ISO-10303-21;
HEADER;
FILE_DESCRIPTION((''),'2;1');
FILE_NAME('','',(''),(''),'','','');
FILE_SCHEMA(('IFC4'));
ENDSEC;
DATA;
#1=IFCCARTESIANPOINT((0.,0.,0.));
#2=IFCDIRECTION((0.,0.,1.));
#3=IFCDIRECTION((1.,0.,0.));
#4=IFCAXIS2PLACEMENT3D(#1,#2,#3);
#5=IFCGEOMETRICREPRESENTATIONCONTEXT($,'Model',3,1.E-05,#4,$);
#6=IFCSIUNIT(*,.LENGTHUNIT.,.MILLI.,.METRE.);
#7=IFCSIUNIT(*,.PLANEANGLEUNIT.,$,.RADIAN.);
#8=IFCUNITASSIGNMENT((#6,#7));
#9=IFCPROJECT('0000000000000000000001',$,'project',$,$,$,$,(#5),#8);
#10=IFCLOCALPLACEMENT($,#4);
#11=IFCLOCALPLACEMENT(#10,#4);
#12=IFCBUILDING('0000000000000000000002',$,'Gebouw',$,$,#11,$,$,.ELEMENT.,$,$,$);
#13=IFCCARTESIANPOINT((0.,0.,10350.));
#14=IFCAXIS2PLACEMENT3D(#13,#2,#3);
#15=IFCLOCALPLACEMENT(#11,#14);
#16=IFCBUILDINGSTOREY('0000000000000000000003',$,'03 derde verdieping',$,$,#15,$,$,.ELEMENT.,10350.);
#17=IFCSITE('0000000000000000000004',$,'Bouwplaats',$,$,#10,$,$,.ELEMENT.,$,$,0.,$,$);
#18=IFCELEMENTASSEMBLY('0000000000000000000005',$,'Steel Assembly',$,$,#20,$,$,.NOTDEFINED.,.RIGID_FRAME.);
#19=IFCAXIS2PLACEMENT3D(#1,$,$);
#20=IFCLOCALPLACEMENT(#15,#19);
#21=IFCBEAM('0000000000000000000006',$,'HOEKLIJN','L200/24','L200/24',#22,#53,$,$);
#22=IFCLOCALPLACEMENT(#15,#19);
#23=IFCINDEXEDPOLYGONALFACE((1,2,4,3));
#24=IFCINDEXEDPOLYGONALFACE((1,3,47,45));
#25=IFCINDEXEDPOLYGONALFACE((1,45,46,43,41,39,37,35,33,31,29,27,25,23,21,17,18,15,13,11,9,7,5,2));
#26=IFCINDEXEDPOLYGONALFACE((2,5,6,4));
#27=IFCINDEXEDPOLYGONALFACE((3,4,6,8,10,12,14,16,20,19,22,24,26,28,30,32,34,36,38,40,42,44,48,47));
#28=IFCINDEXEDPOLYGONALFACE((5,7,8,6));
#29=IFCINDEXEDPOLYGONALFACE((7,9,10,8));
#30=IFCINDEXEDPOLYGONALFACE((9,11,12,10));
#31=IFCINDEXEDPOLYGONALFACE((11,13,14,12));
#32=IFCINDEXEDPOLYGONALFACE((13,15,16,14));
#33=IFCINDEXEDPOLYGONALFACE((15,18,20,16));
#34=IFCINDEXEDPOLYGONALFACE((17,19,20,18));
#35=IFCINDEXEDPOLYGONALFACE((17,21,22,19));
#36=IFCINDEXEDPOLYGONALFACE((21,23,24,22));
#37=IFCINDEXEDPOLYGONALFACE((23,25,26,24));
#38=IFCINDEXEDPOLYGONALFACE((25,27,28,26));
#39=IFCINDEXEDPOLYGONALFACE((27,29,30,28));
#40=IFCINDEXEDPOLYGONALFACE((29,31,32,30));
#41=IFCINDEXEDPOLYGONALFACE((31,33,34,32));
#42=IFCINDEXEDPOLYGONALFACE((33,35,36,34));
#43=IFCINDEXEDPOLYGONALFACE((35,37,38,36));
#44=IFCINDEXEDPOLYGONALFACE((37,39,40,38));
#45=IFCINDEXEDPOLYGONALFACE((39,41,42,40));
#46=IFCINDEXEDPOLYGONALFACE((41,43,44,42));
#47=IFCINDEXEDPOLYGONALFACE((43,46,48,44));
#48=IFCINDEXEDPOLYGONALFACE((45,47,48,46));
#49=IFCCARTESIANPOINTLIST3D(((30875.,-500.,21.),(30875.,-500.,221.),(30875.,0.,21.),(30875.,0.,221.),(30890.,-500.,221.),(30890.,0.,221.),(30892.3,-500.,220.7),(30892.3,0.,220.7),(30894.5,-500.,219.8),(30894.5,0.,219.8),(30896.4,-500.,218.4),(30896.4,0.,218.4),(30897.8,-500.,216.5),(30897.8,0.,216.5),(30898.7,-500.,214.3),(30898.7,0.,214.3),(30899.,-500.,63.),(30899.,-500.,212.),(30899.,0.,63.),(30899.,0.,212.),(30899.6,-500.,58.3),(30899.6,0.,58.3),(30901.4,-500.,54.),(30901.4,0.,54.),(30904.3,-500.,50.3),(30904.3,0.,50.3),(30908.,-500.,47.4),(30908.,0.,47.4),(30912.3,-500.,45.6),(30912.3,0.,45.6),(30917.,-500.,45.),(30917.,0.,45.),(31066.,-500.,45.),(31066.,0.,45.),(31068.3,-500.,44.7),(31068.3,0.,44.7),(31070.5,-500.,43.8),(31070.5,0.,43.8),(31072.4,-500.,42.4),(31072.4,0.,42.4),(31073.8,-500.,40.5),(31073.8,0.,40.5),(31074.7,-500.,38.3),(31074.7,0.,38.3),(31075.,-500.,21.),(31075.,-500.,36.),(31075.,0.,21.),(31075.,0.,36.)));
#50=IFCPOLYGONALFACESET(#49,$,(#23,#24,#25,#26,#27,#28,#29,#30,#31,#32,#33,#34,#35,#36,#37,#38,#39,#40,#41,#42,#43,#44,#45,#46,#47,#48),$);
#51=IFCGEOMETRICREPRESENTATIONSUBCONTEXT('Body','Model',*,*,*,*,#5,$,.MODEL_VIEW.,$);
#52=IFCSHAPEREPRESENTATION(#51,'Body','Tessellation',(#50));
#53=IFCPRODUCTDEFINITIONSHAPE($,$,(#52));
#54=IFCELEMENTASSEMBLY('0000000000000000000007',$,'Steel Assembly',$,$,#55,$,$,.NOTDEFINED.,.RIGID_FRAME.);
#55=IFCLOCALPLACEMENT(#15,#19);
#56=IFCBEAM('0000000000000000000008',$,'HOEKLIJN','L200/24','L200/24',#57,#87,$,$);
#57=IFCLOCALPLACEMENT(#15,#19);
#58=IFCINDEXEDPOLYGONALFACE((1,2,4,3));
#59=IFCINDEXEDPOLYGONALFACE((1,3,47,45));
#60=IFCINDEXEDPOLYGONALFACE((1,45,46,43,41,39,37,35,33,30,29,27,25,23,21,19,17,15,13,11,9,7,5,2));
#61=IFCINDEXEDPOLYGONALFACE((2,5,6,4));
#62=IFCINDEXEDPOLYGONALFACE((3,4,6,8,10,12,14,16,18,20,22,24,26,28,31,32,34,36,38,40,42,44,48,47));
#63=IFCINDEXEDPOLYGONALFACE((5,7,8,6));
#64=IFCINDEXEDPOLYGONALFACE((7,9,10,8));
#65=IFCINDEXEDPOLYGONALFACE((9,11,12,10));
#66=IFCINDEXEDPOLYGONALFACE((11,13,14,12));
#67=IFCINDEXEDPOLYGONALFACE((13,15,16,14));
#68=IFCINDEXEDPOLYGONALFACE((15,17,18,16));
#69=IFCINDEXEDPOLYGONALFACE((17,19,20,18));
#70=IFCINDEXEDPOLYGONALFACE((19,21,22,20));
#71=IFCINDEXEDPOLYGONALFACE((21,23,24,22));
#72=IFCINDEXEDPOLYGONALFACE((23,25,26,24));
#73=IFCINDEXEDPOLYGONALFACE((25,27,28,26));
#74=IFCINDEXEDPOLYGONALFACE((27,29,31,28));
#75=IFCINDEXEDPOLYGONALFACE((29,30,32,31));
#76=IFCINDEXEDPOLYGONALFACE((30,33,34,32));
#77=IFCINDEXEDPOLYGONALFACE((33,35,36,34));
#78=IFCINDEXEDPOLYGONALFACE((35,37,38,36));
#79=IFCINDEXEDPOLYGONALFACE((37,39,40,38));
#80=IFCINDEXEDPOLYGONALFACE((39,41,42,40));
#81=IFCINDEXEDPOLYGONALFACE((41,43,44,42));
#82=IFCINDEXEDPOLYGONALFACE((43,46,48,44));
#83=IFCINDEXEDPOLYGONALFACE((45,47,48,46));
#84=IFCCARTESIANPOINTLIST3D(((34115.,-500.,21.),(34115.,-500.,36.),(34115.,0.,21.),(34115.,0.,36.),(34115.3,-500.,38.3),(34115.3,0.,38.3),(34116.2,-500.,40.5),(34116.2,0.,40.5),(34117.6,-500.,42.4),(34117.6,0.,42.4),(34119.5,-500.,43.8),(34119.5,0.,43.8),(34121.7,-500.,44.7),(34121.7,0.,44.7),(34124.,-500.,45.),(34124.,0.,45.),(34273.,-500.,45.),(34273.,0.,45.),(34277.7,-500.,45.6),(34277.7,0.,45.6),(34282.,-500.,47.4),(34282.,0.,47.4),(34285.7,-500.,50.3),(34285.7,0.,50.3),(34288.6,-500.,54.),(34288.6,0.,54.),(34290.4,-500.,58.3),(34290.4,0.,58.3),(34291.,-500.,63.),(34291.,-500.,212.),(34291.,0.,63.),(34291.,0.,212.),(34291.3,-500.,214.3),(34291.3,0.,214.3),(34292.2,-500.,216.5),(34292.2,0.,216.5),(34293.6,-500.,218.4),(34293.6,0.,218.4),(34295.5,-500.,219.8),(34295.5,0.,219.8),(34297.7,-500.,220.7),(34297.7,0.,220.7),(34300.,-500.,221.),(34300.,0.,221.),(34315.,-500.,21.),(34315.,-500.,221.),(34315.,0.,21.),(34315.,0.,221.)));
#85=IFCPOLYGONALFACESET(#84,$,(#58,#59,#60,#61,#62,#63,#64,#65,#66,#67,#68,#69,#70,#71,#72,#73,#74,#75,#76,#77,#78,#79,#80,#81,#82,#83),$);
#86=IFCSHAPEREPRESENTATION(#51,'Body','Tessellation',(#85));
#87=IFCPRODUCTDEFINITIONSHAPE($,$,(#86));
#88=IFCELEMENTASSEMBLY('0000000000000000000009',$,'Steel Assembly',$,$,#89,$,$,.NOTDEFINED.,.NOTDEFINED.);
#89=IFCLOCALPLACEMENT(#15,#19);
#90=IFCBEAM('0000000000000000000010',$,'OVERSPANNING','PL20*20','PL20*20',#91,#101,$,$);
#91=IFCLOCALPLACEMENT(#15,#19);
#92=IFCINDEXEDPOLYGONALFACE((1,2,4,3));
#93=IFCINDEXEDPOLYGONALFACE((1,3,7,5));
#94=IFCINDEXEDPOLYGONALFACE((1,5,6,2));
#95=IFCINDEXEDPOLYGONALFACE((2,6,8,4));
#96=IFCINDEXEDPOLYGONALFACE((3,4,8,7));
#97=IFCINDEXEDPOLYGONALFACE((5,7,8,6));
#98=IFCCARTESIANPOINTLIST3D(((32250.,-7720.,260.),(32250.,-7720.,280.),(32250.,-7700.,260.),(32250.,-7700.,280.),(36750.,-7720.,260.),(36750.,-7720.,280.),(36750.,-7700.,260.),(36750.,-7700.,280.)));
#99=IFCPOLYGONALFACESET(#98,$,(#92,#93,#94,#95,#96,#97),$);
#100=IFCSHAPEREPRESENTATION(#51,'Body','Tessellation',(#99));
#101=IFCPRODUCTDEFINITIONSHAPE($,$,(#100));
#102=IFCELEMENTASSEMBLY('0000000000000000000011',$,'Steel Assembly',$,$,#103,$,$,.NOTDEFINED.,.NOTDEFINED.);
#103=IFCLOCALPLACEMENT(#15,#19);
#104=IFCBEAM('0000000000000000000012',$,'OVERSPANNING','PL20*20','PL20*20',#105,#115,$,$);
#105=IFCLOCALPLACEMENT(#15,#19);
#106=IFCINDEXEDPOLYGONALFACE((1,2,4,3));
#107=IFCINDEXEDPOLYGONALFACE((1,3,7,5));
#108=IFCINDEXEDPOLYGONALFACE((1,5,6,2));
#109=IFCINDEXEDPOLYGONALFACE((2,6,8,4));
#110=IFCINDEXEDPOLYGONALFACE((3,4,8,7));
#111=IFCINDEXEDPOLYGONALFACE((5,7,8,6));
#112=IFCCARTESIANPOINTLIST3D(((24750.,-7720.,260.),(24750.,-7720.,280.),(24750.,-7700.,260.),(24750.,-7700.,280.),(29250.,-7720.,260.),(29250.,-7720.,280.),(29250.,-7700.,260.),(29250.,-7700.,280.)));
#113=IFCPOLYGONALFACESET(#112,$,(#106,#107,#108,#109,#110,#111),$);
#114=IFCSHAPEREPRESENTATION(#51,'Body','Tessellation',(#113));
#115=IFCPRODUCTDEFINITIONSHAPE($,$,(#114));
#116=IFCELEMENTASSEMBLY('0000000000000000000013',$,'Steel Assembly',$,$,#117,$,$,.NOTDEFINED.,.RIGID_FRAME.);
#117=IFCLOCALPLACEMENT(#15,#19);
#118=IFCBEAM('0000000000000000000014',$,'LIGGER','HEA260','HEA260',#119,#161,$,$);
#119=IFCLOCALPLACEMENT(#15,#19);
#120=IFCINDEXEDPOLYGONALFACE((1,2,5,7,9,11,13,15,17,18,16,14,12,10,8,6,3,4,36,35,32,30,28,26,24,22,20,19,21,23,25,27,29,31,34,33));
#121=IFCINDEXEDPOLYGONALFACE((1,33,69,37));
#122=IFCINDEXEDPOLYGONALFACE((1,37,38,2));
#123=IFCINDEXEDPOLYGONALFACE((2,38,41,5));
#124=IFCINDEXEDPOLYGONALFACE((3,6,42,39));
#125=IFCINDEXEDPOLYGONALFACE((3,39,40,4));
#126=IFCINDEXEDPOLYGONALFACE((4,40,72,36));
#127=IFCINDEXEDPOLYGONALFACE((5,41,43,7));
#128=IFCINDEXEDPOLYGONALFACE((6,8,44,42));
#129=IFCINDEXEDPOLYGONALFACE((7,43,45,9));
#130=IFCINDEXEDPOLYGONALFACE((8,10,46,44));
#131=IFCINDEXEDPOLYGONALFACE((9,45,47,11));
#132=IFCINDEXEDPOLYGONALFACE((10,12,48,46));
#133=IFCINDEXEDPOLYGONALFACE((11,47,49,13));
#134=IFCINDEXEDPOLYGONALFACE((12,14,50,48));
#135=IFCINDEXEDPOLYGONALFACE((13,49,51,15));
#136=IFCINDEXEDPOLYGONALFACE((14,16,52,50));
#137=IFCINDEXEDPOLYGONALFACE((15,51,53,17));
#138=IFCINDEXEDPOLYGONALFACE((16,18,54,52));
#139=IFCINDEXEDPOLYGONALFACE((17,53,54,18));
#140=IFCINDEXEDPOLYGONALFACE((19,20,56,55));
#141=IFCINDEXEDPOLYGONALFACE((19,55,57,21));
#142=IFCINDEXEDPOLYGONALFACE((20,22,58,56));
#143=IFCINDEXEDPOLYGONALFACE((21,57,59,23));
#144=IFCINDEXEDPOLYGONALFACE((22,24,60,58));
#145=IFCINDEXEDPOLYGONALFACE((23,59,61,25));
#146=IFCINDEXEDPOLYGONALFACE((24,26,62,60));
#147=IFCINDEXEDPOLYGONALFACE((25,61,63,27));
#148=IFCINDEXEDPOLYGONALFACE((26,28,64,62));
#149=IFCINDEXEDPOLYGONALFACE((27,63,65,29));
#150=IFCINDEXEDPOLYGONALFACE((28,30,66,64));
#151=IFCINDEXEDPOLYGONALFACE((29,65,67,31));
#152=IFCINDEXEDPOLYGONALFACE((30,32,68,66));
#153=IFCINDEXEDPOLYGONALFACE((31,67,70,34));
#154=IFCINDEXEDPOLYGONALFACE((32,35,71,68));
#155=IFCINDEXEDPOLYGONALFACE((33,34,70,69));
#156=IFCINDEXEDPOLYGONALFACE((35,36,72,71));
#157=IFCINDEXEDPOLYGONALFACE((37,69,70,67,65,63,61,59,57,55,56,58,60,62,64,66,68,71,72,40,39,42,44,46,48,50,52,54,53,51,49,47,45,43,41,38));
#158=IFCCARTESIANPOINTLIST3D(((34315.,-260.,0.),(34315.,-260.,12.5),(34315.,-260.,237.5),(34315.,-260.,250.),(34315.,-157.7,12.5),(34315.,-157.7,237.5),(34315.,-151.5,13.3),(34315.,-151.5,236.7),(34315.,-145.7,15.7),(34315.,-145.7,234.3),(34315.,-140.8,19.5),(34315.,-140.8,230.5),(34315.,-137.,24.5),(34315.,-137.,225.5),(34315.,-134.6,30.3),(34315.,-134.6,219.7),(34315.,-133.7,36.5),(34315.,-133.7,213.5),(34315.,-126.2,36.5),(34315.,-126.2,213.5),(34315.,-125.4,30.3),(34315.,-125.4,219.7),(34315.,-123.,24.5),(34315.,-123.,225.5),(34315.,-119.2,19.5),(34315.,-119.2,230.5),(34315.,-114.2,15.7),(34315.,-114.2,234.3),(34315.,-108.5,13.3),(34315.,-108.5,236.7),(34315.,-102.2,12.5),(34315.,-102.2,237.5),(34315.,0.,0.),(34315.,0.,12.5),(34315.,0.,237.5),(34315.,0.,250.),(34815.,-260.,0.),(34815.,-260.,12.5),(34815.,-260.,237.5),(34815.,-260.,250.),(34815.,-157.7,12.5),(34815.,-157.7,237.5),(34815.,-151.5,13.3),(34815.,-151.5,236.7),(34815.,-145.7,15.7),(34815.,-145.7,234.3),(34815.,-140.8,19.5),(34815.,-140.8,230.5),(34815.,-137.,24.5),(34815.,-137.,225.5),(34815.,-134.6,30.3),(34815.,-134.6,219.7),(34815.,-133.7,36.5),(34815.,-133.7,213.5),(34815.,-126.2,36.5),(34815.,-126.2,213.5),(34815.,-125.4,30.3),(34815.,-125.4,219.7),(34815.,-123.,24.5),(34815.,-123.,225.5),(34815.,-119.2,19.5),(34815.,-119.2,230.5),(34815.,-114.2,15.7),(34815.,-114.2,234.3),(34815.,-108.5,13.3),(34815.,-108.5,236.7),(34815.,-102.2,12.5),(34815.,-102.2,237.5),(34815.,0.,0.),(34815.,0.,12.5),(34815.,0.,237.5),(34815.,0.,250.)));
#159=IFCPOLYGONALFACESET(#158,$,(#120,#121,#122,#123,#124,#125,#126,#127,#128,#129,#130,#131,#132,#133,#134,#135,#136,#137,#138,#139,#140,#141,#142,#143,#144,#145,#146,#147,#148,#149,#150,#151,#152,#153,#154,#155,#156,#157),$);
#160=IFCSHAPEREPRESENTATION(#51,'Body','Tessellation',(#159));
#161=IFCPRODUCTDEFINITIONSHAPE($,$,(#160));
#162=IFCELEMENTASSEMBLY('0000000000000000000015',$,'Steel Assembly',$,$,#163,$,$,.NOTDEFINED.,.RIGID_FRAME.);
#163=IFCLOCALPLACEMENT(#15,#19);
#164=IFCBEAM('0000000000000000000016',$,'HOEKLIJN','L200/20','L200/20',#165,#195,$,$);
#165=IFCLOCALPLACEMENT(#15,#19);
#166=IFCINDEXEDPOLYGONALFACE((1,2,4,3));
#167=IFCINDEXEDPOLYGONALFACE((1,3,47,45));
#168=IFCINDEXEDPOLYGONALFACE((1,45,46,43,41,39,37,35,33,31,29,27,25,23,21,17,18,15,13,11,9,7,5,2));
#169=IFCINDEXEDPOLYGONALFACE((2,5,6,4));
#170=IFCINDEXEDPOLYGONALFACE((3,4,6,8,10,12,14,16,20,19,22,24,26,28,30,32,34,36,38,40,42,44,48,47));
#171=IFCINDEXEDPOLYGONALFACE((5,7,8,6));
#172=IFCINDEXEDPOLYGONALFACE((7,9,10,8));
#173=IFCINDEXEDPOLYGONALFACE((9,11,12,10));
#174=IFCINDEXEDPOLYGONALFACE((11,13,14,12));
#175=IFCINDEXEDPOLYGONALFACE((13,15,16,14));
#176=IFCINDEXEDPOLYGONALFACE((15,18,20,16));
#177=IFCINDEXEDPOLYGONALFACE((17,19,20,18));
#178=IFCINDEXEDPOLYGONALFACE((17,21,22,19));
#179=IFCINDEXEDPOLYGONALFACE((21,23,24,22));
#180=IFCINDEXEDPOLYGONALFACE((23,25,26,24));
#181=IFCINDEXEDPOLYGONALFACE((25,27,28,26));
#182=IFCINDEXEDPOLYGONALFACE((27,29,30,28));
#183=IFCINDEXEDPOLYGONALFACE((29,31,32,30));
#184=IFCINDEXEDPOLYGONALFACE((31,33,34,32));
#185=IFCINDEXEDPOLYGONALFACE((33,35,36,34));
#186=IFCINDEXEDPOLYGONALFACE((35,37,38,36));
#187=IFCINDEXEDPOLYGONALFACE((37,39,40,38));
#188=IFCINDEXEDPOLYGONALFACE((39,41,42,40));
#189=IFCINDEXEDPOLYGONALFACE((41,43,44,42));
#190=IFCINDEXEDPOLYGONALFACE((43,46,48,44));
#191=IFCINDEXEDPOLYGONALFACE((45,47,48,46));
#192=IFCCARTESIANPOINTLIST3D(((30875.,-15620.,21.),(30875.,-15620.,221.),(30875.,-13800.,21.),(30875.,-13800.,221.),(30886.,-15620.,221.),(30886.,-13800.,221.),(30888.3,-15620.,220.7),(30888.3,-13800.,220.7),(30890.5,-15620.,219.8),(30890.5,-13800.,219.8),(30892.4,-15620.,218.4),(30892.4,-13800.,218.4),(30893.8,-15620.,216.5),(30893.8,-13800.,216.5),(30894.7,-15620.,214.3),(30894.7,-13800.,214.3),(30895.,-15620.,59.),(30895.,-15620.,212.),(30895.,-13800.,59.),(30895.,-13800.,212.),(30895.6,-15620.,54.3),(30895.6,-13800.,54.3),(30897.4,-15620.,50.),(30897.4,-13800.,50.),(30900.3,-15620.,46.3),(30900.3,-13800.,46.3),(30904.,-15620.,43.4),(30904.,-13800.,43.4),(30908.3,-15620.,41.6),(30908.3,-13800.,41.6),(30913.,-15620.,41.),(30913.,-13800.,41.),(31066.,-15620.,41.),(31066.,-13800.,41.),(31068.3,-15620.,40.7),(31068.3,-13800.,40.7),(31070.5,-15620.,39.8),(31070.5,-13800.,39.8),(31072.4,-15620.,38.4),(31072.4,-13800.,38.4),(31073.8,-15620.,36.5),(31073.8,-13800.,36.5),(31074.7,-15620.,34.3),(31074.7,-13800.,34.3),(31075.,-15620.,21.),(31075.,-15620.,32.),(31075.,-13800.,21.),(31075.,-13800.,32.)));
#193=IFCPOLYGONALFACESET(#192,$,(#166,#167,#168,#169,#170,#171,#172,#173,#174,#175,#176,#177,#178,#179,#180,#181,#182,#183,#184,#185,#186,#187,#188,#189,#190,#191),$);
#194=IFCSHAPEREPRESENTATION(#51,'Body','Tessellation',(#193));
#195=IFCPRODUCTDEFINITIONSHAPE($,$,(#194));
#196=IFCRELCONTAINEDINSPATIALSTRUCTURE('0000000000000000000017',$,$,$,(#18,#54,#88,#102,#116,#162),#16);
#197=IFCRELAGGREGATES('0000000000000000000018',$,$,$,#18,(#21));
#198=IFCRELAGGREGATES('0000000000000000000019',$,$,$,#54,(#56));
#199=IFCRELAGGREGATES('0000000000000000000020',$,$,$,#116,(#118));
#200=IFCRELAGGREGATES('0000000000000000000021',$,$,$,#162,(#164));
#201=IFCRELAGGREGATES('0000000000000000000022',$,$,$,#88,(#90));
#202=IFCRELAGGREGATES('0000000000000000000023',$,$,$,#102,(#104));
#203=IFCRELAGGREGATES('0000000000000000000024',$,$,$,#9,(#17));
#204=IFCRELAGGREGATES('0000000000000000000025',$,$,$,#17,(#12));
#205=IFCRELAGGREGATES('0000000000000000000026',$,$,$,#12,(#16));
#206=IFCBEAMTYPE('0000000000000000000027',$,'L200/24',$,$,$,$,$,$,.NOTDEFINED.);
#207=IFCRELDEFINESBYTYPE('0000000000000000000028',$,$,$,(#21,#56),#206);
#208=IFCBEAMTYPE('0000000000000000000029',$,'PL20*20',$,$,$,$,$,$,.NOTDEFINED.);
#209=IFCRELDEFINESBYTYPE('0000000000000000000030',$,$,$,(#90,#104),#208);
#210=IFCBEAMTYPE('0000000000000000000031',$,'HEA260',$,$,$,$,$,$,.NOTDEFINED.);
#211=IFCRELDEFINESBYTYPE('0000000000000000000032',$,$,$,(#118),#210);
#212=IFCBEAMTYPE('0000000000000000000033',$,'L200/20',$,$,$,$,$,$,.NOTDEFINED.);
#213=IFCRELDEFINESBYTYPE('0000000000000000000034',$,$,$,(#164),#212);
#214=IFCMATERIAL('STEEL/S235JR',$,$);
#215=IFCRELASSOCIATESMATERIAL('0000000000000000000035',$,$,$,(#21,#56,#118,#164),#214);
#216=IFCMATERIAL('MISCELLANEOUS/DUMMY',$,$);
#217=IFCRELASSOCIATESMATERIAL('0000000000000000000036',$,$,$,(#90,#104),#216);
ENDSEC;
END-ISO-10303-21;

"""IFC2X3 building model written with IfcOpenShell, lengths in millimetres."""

from ifc_helpers import new_model, si_unit, frame, origin_with_axes, origin_2d_with_axis, place, context, subcontext, project, spatial, rectangle, i_section, l_section, extrude, material, type_object, element, aggregate, save


model = new_model("IFC2X3")

# Units and contexts
model_context = context("Model", 3, precision=1e-05, world=origin_with_axes())
body_context = subcontext(model_context, "Body", "Model", "MODEL_VIEW")
ifc_project = project(units=[si_unit("LENGTHUNIT", "METRE", prefix="MILLI"), si_unit("PLANEANGLEUNIT", "RADIAN")], contexts=[model_context])

# Site, building, storey
site_placement = place(None, origin_with_axes())
site = spatial("IfcSite", under=ifc_project, at=site_placement, Name="Bouwplaats", CompositionType="ELEMENT", RefElevation=0.0)
building_placement = place(site_placement, origin_with_axes())
building = spatial("IfcBuilding", under=site, at=building_placement, Name="Gebouw", CompositionType="ELEMENT")
storey_placement = place(building_placement, frame((0.0, 0.0, 10350.0), z_axis=(0.0, 0.0, 1.0), x_axis=(1.0, 0.0, 0.0)))
storey = spatial("IfcBuildingStorey", under=building, at=storey_placement, Name="03 derde verdieping", CompositionType="ELEMENT", Elevation=10350.0)

# Shared definitions
ifc_material_1 = material(Name="STEEL/S235JR")

# Element assemblies, beams
ifc_material_2 = material(Name="MISCELLANEOUS/DUMMY")
beam_type_1 = type_object("IfcBeamType", Name="L200/24", PredefinedType="NOTDEFINED")
assembly_1_placement = place(storey_placement, origin_with_axes())
assembly_1 = element("IfcElementAssembly", 1, at=assembly_1_placement, inside=storey, Name="Steel Assembly", AssemblyPlace="NOTDEFINED", PredefinedType="RIGID_FRAME")
beam_1_placement = place(assembly_1_placement, frame((30975.0, 0.0, 121.0), z_axis=(1.0, 0.0, 0.0), x_axis=(0.0, -1.0, 0.0)))
beam_1 = element("IfcBeam", 2, at=beam_1_placement, type_object=beam_type_1, material=ifc_material_1, Name="HOEKLIJN", Description="L200/24", ObjectType="L200/24", context=body_context, shape_type="SweptSolid", body=[
    extrude(l_section(Depth=200.0, Width=200.0, Thickness=24.0, FilletRadius=18.0, EdgeRadius=9.0, at=origin_2d_with_axis()), frame((500.0, 0.0, 0.0), z_axis=(-1.0, 0.0, 0.0), x_axis=(0.0, -1.0, 0.0)), (0.0, 0.0, 1.0), 500.0),
])
aggregate(assembly_1, [beam_1])
assembly_2_placement = place(storey_placement, origin_with_axes())
assembly_2 = element("IfcElementAssembly", 3, at=assembly_2_placement, inside=storey, Name="Steel Assembly", AssemblyPlace="NOTDEFINED", PredefinedType="RIGID_FRAME")
beam_2_placement = place(assembly_2_placement, frame((34215.0, -500.0, 121.0), z_axis=(-1.0, 0.0, 0.0), x_axis=(0.0, 1.0, 0.0)))
beam_2 = element("IfcBeam", 4, at=beam_2_placement, type_object=beam_type_1, material=ifc_material_1, Name="HOEKLIJN", Description="L200/24", ObjectType="L200/24", context=body_context, shape_type="SweptSolid", body=[
    extrude(l_section(Depth=200.0, Width=200.0, Thickness=24.0, FilletRadius=18.0, EdgeRadius=9.0, at=origin_2d_with_axis()), frame((500.0, 0.0, 0.0), z_axis=(-1.0, 0.0, 0.0), x_axis=(0.0, -1.0, 0.0)), (0.0, 0.0, 1.0), 500.0),
])
aggregate(assembly_2, [beam_2])
assembly_3_placement = place(storey_placement, origin_with_axes())
assembly_3 = element("IfcElementAssembly", 5, at=assembly_3_placement, inside=storey, Name="Steel Assembly", AssemblyPlace="NOTDEFINED", PredefinedType="NOTDEFINED")
beam_type_2 = type_object("IfcBeamType", Name="PL20*20", PredefinedType="NOTDEFINED")
beam_3_placement = place(assembly_3_placement, frame((32250.0, -7710.0, 270.0), z_axis=(0.0, 1.0, 0.0), x_axis=(1.0, 0.0, 0.0)))
beam_3 = element("IfcBeam", 6, at=beam_3_placement, type_object=beam_type_2, material=ifc_material_2, Name="OVERSPANNING", Description="PL20*20", ObjectType="PL20*20", context=body_context, shape_type="SweptSolid", body=[
    extrude(rectangle(XDim=20.0, YDim=20.0, at=origin_2d_with_axis()), frame((4500.0, 0.0, 0.0), z_axis=(-1.0, 0.0, 0.0), x_axis=(0.0, -1.0, 0.0)), (0.0, 0.0, 1.0), 4500.0),
])
assembly_4_placement = place(storey_placement, origin_with_axes())
assembly_4 = element("IfcElementAssembly", 7, at=assembly_4_placement, inside=storey, Name="Steel Assembly", AssemblyPlace="NOTDEFINED", PredefinedType="NOTDEFINED")
beam_4_placement = place(assembly_4_placement, frame((24750.0, -7710.0, 270.0), z_axis=(0.0, 1.0, 0.0), x_axis=(1.0, 0.0, 0.0)))
beam_4 = element("IfcBeam", 8, at=beam_4_placement, type_object=beam_type_2, material=ifc_material_2, Name="OVERSPANNING", Description="PL20*20", ObjectType="PL20*20", context=body_context, shape_type="SweptSolid", body=[
    extrude(rectangle(XDim=20.0, YDim=20.0, at=origin_2d_with_axis()), frame((4500.0, 0.0, 0.0), z_axis=(-1.0, 0.0, 0.0), x_axis=(0.0, -1.0, 0.0)), (0.0, 0.0, 1.0), 4500.0),
])
assembly_5_placement = place(storey_placement, origin_with_axes())
assembly_5 = element("IfcElementAssembly", 9, at=assembly_5_placement, inside=storey, Name="Steel Assembly", AssemblyPlace="NOTDEFINED", PredefinedType="RIGID_FRAME")
beam_type_3 = type_object("IfcBeamType", Name="HEA260", PredefinedType="NOTDEFINED")
beam_5_placement = place(assembly_5_placement, frame((34315.0, -130.0, 125.0), z_axis=(0.0, 0.0, 1.0), x_axis=(1.0, 0.0, 0.0)))
beam_5 = element("IfcBeam", 10, at=beam_5_placement, type_object=beam_type_3, material=ifc_material_1, Name="LIGGER", Description="HEA260", ObjectType="HEA260", context=body_context, shape_type="SweptSolid", body=[
    extrude(i_section(OverallWidth=260.0, OverallDepth=250.0, WebThickness=7.5, FlangeThickness=12.5, FilletRadius=24.0, at=origin_2d_with_axis()), frame((500.0, 0.0, 0.0), z_axis=(-1.0, 0.0, 0.0), x_axis=(0.0, -1.0, 0.0)), (0.0, 0.0, 1.0), 500.0),
])
aggregate(assembly_5, [beam_5])
assembly_6_placement = place(storey_placement, origin_with_axes())
assembly_6 = element("IfcElementAssembly", 11, at=assembly_6_placement, inside=storey, Name="Steel Assembly", AssemblyPlace="NOTDEFINED", PredefinedType="RIGID_FRAME")
beam_type_4 = type_object("IfcBeamType", Name="L200/20", PredefinedType="NOTDEFINED")
beam_6_placement = place(assembly_6_placement, frame((30975.0, -15620.0, 121.0), z_axis=(0.0, 0.0, 1.0), x_axis=(0.0, 1.0, 0.0)))
beam_6 = element("IfcBeam", 12, at=beam_6_placement, type_object=beam_type_4, material=ifc_material_1, Name="HOEKLIJN", Description="L200/20", ObjectType="L200/20", context=body_context, shape_type="SweptSolid", body=[
    extrude(l_section(Depth=200.0, Width=200.0, Thickness=20.0, FilletRadius=18.0, EdgeRadius=9.0, at=origin_2d_with_axis()), frame((1820.0, 0.0, 0.0), z_axis=(-1.0, 0.0, 0.0), x_axis=(0.0, -1.0, 0.0)), (0.0, 0.0, 1.0), 1820.0),
])
aggregate(assembly_6, [beam_6])

aggregate(assembly_3, [beam_3])
aggregate(assembly_4, [beam_4])

save(model, "model.ifc")
